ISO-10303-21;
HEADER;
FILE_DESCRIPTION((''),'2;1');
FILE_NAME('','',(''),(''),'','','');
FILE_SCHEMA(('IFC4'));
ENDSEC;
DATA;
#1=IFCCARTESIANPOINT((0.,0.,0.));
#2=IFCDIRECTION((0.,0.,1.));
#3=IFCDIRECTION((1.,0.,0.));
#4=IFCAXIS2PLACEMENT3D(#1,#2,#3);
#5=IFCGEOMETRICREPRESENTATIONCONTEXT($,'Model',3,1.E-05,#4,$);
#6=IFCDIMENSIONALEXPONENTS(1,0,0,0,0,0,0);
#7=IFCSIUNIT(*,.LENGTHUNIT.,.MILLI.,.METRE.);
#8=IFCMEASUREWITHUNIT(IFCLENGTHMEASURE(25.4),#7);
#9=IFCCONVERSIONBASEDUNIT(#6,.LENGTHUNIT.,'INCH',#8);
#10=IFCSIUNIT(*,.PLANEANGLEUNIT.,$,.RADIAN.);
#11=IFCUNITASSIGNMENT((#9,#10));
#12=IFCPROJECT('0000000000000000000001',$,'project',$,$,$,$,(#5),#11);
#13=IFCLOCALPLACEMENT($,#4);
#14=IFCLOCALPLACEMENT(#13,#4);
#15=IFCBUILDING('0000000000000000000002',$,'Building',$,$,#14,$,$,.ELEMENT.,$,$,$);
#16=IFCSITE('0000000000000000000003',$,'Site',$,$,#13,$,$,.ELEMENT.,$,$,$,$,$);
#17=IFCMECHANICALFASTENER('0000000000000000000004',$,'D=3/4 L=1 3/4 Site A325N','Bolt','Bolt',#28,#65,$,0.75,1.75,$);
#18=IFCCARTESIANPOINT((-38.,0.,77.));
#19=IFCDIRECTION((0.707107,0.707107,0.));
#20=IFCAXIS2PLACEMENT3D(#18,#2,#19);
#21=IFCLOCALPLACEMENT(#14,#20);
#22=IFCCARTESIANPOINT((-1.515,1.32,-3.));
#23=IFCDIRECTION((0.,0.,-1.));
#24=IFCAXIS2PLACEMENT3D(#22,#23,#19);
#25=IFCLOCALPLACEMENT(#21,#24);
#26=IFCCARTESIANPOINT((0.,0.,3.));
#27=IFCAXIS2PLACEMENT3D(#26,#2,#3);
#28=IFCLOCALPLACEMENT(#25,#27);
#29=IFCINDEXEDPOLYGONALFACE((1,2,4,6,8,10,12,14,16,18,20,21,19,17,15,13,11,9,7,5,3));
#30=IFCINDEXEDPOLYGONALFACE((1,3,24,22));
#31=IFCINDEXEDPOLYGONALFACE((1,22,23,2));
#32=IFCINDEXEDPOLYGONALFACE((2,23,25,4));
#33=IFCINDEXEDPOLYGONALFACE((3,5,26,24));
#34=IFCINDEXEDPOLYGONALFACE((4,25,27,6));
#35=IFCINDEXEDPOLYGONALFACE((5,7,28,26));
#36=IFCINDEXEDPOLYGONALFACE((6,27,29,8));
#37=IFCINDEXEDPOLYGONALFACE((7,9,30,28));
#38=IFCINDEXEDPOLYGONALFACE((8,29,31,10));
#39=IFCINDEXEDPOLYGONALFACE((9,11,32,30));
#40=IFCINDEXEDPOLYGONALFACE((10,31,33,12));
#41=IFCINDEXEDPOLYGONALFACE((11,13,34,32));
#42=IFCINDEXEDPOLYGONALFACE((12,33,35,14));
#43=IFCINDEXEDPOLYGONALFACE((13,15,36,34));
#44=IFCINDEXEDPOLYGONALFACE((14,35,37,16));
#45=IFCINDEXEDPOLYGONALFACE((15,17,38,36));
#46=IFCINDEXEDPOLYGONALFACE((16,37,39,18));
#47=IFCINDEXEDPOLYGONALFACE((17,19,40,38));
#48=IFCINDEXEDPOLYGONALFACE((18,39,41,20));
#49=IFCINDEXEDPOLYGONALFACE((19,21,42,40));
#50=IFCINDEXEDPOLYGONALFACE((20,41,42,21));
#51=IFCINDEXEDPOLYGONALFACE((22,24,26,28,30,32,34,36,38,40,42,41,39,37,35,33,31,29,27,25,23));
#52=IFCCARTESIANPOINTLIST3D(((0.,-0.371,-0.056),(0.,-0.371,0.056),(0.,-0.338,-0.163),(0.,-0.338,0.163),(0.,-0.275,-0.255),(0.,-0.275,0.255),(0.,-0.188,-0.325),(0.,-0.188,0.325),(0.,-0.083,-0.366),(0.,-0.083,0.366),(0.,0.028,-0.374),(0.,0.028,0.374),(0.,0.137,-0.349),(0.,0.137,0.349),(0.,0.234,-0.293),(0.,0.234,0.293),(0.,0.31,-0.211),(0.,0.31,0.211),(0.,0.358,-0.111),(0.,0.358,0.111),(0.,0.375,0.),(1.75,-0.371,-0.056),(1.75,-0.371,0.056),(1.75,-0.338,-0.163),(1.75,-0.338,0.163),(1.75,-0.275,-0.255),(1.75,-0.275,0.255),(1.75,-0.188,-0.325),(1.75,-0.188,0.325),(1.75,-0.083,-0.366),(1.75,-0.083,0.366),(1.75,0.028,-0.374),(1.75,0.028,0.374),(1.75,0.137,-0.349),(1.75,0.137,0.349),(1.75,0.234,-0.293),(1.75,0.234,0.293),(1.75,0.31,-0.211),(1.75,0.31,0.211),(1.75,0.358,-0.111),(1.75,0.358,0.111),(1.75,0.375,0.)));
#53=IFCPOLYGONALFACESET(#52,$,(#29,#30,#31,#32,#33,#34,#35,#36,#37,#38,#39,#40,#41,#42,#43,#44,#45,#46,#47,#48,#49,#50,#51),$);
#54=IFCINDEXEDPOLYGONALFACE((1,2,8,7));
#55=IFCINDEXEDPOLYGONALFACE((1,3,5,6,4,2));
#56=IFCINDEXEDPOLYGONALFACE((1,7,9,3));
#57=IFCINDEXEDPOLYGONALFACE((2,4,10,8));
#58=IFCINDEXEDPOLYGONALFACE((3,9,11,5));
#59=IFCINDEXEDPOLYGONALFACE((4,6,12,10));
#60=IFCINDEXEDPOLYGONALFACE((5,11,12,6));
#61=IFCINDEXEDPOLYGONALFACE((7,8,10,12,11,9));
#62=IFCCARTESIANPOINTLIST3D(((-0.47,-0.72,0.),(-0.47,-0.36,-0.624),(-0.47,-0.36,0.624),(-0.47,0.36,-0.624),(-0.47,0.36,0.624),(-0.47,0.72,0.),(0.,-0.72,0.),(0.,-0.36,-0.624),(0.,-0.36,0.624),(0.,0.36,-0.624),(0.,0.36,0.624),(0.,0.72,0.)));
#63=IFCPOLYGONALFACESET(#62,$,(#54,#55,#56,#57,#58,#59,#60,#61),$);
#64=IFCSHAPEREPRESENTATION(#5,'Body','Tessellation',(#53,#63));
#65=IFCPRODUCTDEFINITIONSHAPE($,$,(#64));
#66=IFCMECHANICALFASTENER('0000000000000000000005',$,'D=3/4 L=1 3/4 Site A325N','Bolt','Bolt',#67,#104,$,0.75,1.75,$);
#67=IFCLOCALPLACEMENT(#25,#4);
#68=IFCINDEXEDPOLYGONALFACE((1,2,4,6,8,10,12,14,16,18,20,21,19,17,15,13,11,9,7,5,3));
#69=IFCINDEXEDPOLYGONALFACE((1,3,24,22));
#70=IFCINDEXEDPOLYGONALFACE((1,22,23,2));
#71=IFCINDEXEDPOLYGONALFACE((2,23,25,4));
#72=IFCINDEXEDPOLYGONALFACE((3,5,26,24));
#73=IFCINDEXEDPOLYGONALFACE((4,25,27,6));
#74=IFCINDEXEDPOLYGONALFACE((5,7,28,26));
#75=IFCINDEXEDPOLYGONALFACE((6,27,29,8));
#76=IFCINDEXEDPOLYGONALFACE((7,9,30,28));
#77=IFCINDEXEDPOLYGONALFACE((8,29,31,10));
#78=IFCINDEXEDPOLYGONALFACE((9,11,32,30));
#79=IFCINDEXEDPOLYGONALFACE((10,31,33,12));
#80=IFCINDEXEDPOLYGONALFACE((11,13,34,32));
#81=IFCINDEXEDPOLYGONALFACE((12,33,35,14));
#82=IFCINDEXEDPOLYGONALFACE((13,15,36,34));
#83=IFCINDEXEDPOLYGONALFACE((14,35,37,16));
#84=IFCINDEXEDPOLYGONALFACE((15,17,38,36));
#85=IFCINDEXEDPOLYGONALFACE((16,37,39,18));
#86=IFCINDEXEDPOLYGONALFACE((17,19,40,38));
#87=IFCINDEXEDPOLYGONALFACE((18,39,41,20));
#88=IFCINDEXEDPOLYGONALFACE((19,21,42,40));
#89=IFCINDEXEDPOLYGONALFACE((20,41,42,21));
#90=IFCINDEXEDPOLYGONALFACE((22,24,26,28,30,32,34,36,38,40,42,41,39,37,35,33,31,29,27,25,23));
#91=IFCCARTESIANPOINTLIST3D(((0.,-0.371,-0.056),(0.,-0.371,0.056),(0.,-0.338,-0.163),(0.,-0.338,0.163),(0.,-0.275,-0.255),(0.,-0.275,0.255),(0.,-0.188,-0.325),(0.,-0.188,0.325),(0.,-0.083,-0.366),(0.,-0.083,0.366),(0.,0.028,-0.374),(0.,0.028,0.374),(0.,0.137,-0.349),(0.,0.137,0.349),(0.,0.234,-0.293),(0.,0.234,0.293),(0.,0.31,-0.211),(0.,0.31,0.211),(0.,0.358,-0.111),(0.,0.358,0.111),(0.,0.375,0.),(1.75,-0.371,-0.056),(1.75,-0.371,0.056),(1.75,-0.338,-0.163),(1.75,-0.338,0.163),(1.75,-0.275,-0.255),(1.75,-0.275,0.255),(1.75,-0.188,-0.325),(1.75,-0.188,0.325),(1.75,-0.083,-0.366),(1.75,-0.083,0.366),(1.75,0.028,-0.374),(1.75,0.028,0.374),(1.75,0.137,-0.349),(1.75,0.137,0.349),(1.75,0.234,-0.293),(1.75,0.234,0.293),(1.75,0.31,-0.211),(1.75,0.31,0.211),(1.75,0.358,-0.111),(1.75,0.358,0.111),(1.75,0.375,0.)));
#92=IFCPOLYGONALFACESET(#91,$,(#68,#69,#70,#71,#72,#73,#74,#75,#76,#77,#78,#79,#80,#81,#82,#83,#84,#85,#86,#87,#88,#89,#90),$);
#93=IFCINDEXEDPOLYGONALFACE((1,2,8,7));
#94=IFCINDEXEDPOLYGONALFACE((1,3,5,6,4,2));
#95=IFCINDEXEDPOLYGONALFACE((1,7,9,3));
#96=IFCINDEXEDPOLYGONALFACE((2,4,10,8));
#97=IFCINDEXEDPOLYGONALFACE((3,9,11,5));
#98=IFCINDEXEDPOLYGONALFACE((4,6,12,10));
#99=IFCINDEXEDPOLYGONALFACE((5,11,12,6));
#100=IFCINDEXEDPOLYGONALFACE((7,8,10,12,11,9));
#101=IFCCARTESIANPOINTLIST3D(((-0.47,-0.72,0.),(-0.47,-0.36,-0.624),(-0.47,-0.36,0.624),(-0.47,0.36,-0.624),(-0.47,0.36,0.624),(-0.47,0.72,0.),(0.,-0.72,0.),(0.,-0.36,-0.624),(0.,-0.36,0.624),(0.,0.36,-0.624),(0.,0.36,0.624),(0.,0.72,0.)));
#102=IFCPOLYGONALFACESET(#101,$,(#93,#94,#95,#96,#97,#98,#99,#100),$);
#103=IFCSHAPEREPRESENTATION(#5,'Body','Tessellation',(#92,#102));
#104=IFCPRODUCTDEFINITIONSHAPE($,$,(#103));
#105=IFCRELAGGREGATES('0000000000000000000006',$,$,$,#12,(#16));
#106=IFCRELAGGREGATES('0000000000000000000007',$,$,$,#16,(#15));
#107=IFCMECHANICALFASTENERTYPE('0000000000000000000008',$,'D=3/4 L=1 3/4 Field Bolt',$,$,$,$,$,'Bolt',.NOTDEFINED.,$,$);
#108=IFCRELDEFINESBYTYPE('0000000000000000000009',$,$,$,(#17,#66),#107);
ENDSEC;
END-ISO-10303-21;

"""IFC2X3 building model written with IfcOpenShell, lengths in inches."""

from ifc_helpers import new_model, entity, si_unit, converted_unit, frame, origin_with_axes, origin_2d_with_axis, place, context, project, spatial, polyline, circle, outline, extrude, source, transform, mapped, type_object, type_shapes, element, save


model = new_model("IFC2X3")

# Units and contexts
model_context = context("Model", 3, precision=1e-05, world=origin_with_axes())
ifc_project = project(units=[converted_unit("LENGTHUNIT", "INCH", entity("IfcLengthMeasure", 25.4), si_unit("LENGTHUNIT", "METRE", prefix="MILLI"), dimensions=[1, 0, 0, 0, 0, 0, 0]), si_unit("PLANEANGLEUNIT", "RADIAN")], contexts=[model_context])

# Site, building
site_placement = place(None, origin_with_axes())
site = spatial("IfcSite", under=ifc_project, at=site_placement, Name="Site", CompositionType="ELEMENT")
building_placement = place(site_placement, origin_with_axes())
building = spatial("IfcBuilding", under=site, at=building_placement, Name="Building", CompositionType="ELEMENT")

# Shared definitions
assembly_placement = place(building_placement, frame((-38.0, 0.0, 77.0), z_axis=(0.0, 0.0, 1.0), x_axis=(0.707107, 0.707107, 0.0)))

# Mechanical fasteners
mechanical_fastener_type_1 = type_object("IfcMechanicalFastenerType", Name="D=3/4 L=1 3/4 Field Bolt", ElementType="Bolt")
shared_shape_1 = source(origin_with_axes(), model_context, "Body", "SweptSolid", [
    extrude(circle(Radius=0.375, at=origin_2d_with_axis()), frame((0.0, 0.0, 0.0), z_axis=(1.0, 0.0, 0.0), x_axis=(0.0, 1.0, 0.0)), (0.0, 0.0, 1.0), 1.75),
    extrude(outline(polyline([(-0.72, 0.0), (-0.36, 0.624), (0.36, 0.624), (0.72, 0.0), (0.36, -0.624), (-0.36, -0.624), (-0.72, 0.0)])), frame((0.0, 0.0, 0.0), z_axis=(1.0, 0.0, 0.0), x_axis=(0.0, 1.0, 0.0)), (0.0, 0.0, -1.0), 0.47),
])
type_shapes(mechanical_fastener_type_1, [shared_shape_1])
placement_1 = place(assembly_placement, frame((-1.515, 1.32, -3.0), z_axis=(0.0, 0.0, -1.0), x_axis=(0.707107, 0.707107, 0.0)))
for number, where, z_axis, x_axis, name in (
    (1, (0.0, 0.0, 3.0), (0.0, 0.0, 1.0), (1.0, 0.0, 0.0), "D=3/4 L=1 3/4 Site A325N"),
    (2, (0.0, 0.0, 0.0), (0.0, 0.0, 1.0), (1.0, 0.0, 0.0), "D=3/4 L=1 3/4 Site A325N"),
):
    element("IfcMechanicalFastener", number, at=place(placement_1, frame(where, z_axis=z_axis, x_axis=x_axis)), type_object=mechanical_fastener_type_1, Name=name, Description="Bolt", ObjectType="Bolt", NominalDiameter=0.75, NominalLength=1.75, context=model_context, shape_type="MappedRepresentation", body=[
        mapped(shared_shape_1, transform((0.0, 0.0, 0.0), scale=1.0)),
    ])

save(model, "model.ifc")
